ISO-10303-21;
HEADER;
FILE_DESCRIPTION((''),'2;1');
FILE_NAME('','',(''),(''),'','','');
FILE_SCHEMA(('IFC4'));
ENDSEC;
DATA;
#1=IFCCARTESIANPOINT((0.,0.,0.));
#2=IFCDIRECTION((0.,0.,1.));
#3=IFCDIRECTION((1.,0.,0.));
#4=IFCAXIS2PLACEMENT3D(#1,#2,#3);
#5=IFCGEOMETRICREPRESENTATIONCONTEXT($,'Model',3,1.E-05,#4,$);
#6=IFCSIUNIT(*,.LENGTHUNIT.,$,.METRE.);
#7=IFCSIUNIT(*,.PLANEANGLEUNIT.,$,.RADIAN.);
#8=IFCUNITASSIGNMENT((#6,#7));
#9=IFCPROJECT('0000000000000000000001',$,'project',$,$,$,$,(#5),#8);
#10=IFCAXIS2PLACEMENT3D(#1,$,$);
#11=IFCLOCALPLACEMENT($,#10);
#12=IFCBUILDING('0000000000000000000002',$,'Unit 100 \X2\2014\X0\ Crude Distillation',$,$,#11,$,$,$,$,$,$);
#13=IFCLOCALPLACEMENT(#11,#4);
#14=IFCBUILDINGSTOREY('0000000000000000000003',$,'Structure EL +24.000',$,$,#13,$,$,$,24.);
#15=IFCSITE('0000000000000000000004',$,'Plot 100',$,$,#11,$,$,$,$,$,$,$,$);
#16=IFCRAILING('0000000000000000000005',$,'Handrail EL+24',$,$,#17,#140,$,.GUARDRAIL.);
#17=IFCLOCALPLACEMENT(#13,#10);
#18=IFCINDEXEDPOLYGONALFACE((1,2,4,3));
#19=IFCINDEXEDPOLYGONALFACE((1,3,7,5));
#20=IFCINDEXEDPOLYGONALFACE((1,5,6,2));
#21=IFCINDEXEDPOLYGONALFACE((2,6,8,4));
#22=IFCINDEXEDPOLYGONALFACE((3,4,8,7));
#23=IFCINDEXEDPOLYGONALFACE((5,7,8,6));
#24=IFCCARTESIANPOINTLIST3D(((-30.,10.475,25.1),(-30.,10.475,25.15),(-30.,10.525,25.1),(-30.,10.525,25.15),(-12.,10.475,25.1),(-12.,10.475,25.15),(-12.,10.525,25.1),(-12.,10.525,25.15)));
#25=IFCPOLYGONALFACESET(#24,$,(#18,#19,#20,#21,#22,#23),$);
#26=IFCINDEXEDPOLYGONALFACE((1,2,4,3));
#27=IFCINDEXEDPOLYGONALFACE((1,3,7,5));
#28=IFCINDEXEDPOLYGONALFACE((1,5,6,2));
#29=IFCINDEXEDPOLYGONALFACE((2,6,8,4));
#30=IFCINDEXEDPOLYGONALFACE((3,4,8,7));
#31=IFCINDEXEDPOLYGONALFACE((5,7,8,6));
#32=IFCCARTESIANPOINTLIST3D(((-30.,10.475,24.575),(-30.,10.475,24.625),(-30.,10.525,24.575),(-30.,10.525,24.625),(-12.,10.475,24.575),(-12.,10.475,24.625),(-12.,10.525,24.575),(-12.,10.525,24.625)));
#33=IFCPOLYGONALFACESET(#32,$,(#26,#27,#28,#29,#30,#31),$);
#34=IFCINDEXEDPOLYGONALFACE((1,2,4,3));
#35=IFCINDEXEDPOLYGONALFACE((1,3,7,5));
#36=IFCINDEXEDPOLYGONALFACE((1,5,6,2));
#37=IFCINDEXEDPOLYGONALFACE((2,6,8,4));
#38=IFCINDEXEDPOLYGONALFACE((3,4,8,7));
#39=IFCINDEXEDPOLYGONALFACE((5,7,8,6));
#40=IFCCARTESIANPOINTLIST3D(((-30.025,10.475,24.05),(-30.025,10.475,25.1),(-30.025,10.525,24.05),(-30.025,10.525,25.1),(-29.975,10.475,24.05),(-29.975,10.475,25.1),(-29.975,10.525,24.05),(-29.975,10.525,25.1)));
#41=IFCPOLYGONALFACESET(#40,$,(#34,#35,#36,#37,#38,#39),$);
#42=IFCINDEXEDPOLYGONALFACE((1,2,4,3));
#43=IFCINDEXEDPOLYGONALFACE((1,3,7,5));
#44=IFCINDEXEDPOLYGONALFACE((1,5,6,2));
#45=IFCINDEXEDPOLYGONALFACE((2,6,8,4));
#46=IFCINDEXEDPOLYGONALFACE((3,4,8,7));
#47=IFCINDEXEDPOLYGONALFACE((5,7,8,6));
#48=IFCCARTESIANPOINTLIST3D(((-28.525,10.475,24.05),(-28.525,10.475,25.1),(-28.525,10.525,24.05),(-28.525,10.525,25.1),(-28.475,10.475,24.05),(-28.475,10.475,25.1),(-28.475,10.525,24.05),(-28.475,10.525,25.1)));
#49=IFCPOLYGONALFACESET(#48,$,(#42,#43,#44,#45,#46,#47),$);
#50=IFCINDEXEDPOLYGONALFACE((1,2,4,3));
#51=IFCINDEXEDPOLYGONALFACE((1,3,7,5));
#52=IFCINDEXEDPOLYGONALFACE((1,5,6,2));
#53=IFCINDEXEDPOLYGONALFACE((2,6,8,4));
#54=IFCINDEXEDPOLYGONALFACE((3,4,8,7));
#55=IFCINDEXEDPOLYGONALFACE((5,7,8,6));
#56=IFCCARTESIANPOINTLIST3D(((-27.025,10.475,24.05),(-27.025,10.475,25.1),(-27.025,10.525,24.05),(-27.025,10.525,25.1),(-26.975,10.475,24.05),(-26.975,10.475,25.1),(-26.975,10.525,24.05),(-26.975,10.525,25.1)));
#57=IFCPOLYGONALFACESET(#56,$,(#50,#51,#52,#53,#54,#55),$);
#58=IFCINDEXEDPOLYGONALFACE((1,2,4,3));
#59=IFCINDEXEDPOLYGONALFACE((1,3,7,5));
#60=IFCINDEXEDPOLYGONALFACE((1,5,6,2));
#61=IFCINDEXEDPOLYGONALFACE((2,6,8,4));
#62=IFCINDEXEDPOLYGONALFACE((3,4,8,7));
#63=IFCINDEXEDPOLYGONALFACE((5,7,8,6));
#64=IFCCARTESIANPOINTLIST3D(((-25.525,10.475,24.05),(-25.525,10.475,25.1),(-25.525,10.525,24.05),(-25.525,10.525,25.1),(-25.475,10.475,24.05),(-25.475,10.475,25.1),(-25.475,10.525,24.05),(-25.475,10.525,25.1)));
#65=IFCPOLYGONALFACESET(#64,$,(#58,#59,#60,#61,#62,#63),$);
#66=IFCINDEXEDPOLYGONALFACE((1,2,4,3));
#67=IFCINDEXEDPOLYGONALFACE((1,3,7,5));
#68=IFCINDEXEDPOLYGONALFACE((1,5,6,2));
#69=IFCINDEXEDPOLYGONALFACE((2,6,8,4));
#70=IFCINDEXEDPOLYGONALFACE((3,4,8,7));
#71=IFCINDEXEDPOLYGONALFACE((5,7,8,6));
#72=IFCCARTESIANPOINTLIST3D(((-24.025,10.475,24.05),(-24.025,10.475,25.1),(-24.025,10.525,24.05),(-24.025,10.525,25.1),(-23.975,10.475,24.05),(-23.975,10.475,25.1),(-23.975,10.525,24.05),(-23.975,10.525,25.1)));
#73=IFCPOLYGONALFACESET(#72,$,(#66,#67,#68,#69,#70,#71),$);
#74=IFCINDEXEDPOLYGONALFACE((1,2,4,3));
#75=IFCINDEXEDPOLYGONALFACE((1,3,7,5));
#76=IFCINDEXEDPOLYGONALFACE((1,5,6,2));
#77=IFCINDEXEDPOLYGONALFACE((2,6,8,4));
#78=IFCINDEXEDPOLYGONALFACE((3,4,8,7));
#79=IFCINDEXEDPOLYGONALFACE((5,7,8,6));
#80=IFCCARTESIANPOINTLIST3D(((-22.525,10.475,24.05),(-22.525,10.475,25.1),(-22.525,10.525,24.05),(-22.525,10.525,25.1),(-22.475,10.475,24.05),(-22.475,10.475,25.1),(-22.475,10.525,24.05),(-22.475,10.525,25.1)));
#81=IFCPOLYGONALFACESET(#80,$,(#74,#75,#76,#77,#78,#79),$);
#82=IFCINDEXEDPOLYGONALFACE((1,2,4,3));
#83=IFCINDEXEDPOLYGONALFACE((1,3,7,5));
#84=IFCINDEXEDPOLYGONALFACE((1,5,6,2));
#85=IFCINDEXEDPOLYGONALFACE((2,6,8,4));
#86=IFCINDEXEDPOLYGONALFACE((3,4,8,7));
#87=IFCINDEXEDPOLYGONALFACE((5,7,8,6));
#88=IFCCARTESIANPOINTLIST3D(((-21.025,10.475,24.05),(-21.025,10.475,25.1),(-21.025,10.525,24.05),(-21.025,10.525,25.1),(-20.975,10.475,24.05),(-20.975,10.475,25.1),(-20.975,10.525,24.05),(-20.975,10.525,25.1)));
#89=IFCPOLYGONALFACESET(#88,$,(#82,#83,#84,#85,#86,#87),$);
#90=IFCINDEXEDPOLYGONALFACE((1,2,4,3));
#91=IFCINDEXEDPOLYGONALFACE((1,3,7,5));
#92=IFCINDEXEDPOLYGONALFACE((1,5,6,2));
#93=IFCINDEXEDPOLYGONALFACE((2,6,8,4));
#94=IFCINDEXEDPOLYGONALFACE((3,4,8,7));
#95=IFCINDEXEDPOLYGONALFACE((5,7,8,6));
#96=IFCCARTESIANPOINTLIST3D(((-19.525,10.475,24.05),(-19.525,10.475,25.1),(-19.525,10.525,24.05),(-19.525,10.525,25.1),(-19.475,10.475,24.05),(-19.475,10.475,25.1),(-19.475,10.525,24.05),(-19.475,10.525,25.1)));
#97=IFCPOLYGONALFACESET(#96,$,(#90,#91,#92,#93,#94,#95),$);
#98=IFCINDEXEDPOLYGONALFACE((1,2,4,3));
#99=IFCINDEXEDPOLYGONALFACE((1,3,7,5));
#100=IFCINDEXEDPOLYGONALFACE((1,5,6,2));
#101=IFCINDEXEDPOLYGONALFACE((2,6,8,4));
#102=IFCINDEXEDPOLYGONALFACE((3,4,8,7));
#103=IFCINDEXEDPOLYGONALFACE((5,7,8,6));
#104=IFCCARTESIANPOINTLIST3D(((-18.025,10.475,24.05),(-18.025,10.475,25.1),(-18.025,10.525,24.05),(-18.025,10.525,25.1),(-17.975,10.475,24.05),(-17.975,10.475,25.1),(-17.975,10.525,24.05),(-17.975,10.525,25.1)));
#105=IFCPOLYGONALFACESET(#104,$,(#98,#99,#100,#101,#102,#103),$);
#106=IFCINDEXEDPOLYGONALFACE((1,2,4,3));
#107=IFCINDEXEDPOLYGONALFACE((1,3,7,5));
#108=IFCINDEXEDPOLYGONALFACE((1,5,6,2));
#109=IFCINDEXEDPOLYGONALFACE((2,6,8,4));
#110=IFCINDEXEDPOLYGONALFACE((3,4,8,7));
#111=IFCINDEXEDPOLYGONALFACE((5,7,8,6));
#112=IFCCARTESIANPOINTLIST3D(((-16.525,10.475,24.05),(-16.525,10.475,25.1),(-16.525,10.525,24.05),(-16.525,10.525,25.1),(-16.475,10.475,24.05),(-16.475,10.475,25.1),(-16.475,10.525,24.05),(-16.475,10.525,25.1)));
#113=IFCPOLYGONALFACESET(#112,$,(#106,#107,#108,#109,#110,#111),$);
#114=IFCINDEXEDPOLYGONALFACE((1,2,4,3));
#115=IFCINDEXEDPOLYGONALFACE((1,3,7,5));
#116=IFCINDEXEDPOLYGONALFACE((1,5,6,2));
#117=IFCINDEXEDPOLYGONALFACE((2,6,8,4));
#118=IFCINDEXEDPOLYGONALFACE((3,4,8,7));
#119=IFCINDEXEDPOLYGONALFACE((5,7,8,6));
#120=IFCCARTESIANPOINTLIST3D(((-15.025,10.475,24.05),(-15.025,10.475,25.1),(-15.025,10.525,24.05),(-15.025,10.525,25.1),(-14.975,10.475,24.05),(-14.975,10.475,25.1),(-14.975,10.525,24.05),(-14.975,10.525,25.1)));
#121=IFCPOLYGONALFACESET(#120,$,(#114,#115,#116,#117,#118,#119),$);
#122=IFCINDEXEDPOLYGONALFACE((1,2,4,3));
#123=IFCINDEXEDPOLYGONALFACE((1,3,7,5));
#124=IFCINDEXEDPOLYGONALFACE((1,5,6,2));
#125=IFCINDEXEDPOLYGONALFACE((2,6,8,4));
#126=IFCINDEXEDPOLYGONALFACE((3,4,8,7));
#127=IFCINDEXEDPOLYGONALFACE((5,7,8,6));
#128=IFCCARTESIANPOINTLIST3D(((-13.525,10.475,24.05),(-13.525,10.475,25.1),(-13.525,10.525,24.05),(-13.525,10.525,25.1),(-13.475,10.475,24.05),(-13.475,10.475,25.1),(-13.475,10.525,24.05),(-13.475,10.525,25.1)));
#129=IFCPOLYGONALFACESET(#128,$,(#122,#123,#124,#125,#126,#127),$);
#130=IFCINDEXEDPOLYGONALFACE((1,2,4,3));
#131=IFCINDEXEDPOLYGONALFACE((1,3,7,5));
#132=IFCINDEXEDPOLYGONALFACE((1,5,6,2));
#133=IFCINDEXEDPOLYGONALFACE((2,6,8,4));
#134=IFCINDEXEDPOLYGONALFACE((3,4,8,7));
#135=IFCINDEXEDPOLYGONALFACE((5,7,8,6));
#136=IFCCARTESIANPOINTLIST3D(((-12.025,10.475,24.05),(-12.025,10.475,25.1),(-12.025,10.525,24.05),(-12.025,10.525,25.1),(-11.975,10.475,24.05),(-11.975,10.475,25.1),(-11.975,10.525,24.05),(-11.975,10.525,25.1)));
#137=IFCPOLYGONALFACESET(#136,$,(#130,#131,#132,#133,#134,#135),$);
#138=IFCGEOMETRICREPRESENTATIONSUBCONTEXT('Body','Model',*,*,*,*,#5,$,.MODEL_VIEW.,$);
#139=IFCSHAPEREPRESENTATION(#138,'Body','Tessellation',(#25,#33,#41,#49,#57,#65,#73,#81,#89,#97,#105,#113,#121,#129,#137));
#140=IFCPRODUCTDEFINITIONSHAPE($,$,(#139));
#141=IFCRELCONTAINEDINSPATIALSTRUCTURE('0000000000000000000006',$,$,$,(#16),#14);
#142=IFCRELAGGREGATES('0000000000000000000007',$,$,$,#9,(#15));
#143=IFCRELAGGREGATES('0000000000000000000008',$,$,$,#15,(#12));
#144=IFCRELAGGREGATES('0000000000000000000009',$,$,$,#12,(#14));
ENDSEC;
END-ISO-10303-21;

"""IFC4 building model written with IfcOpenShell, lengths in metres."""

from ifc_helpers import new_model, si_unit, frame, origin, origin_with_axes, origin_2d, place, context, subcontext, project, spatial, rectangle, extrude, element, save


model = new_model("IFC4")

# Units and contexts
model_context = context("Model", 3, precision=1e-05, world=origin_with_axes())
body_context = subcontext(model_context, "Body", "Model", "MODEL_VIEW")
ifc_project = project(units=[si_unit("LENGTHUNIT", "METRE"), si_unit("PLANEANGLEUNIT", "RADIAN")], contexts=[model_context])

# Site, building, storey
placement = place(None, origin())
site = spatial("IfcSite", under=ifc_project, at=placement, Name="Plot 100")
building = spatial("IfcBuilding", under=site, at=placement, Name="Unit 100 — Crude Distillation")
storey_placement = place(placement, origin_with_axes())
storey = spatial("IfcBuildingStorey", under=building, at=storey_placement, Name="Structure EL +24.000", Elevation=24.0)

# Railing
railing_1_placement = place(storey_placement, origin_with_axes())
element("IfcRailing", 1, at=railing_1_placement, inside=storey, Name="Handrail EL+24", PredefinedType="GUARDRAIL", context=body_context, shape_type="SweptSolid", body=[
    extrude(rectangle(XDim=0.05, YDim=0.05, at=origin_2d()), frame((-30.0, 10.5, 25.125), z_axis=(1.0, 0.0, 0.0), x_axis=(0.0, 1.0, 0.0)), (0.0, 0.0, 1.0), 18.0),
    extrude(rectangle(XDim=0.05, YDim=0.05, at=origin_2d()), frame((-30.0, 10.5, 24.6), z_axis=(1.0, 0.0, 0.0), x_axis=(0.0, 1.0, 0.0)), (0.0, 0.0, 1.0), 18.0),
    extrude(rectangle(XDim=0.05, YDim=0.05, at=origin_2d()), frame((-30.0, 10.5, 24.05), z_axis=(0.0, 0.0, 1.0), x_axis=(1.0, 0.0, 0.0)), (0.0, 0.0, 1.0), 1.05),
    extrude(rectangle(XDim=0.05, YDim=0.05, at=origin_2d()), frame((-28.5, 10.5, 24.05), z_axis=(0.0, 0.0, 1.0), x_axis=(1.0, 0.0, 0.0)), (0.0, 0.0, 1.0), 1.05),
    extrude(rectangle(XDim=0.05, YDim=0.05, at=origin_2d()), frame((-27.0, 10.5, 24.05), z_axis=(0.0, 0.0, 1.0), x_axis=(1.0, 0.0, 0.0)), (0.0, 0.0, 1.0), 1.05),
    extrude(rectangle(XDim=0.05, YDim=0.05, at=origin_2d()), frame((-25.5, 10.5, 24.05), z_axis=(0.0, 0.0, 1.0), x_axis=(1.0, 0.0, 0.0)), (0.0, 0.0, 1.0), 1.05),
    extrude(rectangle(XDim=0.05, YDim=0.05, at=origin_2d()), frame((-24.0, 10.5, 24.05), z_axis=(0.0, 0.0, 1.0), x_axis=(1.0, 0.0, 0.0)), (0.0, 0.0, 1.0), 1.05),
    extrude(rectangle(XDim=0.05, YDim=0.05, at=origin_2d()), frame((-22.5, 10.5, 24.05), z_axis=(0.0, 0.0, 1.0), x_axis=(1.0, 0.0, 0.0)), (0.0, 0.0, 1.0), 1.05),
    extrude(rectangle(XDim=0.05, YDim=0.05, at=origin_2d()), frame((-21.0, 10.5, 24.05), z_axis=(0.0, 0.0, 1.0), x_axis=(1.0, 0.0, 0.0)), (0.0, 0.0, 1.0), 1.05),
    extrude(rectangle(XDim=0.05, YDim=0.05, at=origin_2d()), frame((-19.5, 10.5, 24.05), z_axis=(0.0, 0.0, 1.0), x_axis=(1.0, 0.0, 0.0)), (0.0, 0.0, 1.0), 1.05),
    extrude(rectangle(XDim=0.05, YDim=0.05, at=origin_2d()), frame((-18.0, 10.5, 24.05), z_axis=(0.0, 0.0, 1.0), x_axis=(1.0, 0.0, 0.0)), (0.0, 0.0, 1.0), 1.05),
    extrude(rectangle(XDim=0.05, YDim=0.05, at=origin_2d()), frame((-16.5, 10.5, 24.05), z_axis=(0.0, 0.0, 1.0), x_axis=(1.0, 0.0, 0.0)), (0.0, 0.0, 1.0), 1.05),
    extrude(rectangle(XDim=0.05, YDim=0.05, at=origin_2d()), frame((-15.0, 10.5, 24.05), z_axis=(0.0, 0.0, 1.0), x_axis=(1.0, 0.0, 0.0)), (0.0, 0.0, 1.0), 1.05),
    extrude(rectangle(XDim=0.05, YDim=0.05, at=origin_2d()), frame((-13.5, 10.5, 24.05), z_axis=(0.0, 0.0, 1.0), x_axis=(1.0, 0.0, 0.0)), (0.0, 0.0, 1.0), 1.05),
    extrude(rectangle(XDim=0.05, YDim=0.05, at=origin_2d()), frame((-12.0, 10.5, 24.05), z_axis=(0.0, 0.0, 1.0), x_axis=(1.0, 0.0, 0.0)), (0.0, 0.0, 1.0), 1.05),
])

save(model, "model.ifc")
